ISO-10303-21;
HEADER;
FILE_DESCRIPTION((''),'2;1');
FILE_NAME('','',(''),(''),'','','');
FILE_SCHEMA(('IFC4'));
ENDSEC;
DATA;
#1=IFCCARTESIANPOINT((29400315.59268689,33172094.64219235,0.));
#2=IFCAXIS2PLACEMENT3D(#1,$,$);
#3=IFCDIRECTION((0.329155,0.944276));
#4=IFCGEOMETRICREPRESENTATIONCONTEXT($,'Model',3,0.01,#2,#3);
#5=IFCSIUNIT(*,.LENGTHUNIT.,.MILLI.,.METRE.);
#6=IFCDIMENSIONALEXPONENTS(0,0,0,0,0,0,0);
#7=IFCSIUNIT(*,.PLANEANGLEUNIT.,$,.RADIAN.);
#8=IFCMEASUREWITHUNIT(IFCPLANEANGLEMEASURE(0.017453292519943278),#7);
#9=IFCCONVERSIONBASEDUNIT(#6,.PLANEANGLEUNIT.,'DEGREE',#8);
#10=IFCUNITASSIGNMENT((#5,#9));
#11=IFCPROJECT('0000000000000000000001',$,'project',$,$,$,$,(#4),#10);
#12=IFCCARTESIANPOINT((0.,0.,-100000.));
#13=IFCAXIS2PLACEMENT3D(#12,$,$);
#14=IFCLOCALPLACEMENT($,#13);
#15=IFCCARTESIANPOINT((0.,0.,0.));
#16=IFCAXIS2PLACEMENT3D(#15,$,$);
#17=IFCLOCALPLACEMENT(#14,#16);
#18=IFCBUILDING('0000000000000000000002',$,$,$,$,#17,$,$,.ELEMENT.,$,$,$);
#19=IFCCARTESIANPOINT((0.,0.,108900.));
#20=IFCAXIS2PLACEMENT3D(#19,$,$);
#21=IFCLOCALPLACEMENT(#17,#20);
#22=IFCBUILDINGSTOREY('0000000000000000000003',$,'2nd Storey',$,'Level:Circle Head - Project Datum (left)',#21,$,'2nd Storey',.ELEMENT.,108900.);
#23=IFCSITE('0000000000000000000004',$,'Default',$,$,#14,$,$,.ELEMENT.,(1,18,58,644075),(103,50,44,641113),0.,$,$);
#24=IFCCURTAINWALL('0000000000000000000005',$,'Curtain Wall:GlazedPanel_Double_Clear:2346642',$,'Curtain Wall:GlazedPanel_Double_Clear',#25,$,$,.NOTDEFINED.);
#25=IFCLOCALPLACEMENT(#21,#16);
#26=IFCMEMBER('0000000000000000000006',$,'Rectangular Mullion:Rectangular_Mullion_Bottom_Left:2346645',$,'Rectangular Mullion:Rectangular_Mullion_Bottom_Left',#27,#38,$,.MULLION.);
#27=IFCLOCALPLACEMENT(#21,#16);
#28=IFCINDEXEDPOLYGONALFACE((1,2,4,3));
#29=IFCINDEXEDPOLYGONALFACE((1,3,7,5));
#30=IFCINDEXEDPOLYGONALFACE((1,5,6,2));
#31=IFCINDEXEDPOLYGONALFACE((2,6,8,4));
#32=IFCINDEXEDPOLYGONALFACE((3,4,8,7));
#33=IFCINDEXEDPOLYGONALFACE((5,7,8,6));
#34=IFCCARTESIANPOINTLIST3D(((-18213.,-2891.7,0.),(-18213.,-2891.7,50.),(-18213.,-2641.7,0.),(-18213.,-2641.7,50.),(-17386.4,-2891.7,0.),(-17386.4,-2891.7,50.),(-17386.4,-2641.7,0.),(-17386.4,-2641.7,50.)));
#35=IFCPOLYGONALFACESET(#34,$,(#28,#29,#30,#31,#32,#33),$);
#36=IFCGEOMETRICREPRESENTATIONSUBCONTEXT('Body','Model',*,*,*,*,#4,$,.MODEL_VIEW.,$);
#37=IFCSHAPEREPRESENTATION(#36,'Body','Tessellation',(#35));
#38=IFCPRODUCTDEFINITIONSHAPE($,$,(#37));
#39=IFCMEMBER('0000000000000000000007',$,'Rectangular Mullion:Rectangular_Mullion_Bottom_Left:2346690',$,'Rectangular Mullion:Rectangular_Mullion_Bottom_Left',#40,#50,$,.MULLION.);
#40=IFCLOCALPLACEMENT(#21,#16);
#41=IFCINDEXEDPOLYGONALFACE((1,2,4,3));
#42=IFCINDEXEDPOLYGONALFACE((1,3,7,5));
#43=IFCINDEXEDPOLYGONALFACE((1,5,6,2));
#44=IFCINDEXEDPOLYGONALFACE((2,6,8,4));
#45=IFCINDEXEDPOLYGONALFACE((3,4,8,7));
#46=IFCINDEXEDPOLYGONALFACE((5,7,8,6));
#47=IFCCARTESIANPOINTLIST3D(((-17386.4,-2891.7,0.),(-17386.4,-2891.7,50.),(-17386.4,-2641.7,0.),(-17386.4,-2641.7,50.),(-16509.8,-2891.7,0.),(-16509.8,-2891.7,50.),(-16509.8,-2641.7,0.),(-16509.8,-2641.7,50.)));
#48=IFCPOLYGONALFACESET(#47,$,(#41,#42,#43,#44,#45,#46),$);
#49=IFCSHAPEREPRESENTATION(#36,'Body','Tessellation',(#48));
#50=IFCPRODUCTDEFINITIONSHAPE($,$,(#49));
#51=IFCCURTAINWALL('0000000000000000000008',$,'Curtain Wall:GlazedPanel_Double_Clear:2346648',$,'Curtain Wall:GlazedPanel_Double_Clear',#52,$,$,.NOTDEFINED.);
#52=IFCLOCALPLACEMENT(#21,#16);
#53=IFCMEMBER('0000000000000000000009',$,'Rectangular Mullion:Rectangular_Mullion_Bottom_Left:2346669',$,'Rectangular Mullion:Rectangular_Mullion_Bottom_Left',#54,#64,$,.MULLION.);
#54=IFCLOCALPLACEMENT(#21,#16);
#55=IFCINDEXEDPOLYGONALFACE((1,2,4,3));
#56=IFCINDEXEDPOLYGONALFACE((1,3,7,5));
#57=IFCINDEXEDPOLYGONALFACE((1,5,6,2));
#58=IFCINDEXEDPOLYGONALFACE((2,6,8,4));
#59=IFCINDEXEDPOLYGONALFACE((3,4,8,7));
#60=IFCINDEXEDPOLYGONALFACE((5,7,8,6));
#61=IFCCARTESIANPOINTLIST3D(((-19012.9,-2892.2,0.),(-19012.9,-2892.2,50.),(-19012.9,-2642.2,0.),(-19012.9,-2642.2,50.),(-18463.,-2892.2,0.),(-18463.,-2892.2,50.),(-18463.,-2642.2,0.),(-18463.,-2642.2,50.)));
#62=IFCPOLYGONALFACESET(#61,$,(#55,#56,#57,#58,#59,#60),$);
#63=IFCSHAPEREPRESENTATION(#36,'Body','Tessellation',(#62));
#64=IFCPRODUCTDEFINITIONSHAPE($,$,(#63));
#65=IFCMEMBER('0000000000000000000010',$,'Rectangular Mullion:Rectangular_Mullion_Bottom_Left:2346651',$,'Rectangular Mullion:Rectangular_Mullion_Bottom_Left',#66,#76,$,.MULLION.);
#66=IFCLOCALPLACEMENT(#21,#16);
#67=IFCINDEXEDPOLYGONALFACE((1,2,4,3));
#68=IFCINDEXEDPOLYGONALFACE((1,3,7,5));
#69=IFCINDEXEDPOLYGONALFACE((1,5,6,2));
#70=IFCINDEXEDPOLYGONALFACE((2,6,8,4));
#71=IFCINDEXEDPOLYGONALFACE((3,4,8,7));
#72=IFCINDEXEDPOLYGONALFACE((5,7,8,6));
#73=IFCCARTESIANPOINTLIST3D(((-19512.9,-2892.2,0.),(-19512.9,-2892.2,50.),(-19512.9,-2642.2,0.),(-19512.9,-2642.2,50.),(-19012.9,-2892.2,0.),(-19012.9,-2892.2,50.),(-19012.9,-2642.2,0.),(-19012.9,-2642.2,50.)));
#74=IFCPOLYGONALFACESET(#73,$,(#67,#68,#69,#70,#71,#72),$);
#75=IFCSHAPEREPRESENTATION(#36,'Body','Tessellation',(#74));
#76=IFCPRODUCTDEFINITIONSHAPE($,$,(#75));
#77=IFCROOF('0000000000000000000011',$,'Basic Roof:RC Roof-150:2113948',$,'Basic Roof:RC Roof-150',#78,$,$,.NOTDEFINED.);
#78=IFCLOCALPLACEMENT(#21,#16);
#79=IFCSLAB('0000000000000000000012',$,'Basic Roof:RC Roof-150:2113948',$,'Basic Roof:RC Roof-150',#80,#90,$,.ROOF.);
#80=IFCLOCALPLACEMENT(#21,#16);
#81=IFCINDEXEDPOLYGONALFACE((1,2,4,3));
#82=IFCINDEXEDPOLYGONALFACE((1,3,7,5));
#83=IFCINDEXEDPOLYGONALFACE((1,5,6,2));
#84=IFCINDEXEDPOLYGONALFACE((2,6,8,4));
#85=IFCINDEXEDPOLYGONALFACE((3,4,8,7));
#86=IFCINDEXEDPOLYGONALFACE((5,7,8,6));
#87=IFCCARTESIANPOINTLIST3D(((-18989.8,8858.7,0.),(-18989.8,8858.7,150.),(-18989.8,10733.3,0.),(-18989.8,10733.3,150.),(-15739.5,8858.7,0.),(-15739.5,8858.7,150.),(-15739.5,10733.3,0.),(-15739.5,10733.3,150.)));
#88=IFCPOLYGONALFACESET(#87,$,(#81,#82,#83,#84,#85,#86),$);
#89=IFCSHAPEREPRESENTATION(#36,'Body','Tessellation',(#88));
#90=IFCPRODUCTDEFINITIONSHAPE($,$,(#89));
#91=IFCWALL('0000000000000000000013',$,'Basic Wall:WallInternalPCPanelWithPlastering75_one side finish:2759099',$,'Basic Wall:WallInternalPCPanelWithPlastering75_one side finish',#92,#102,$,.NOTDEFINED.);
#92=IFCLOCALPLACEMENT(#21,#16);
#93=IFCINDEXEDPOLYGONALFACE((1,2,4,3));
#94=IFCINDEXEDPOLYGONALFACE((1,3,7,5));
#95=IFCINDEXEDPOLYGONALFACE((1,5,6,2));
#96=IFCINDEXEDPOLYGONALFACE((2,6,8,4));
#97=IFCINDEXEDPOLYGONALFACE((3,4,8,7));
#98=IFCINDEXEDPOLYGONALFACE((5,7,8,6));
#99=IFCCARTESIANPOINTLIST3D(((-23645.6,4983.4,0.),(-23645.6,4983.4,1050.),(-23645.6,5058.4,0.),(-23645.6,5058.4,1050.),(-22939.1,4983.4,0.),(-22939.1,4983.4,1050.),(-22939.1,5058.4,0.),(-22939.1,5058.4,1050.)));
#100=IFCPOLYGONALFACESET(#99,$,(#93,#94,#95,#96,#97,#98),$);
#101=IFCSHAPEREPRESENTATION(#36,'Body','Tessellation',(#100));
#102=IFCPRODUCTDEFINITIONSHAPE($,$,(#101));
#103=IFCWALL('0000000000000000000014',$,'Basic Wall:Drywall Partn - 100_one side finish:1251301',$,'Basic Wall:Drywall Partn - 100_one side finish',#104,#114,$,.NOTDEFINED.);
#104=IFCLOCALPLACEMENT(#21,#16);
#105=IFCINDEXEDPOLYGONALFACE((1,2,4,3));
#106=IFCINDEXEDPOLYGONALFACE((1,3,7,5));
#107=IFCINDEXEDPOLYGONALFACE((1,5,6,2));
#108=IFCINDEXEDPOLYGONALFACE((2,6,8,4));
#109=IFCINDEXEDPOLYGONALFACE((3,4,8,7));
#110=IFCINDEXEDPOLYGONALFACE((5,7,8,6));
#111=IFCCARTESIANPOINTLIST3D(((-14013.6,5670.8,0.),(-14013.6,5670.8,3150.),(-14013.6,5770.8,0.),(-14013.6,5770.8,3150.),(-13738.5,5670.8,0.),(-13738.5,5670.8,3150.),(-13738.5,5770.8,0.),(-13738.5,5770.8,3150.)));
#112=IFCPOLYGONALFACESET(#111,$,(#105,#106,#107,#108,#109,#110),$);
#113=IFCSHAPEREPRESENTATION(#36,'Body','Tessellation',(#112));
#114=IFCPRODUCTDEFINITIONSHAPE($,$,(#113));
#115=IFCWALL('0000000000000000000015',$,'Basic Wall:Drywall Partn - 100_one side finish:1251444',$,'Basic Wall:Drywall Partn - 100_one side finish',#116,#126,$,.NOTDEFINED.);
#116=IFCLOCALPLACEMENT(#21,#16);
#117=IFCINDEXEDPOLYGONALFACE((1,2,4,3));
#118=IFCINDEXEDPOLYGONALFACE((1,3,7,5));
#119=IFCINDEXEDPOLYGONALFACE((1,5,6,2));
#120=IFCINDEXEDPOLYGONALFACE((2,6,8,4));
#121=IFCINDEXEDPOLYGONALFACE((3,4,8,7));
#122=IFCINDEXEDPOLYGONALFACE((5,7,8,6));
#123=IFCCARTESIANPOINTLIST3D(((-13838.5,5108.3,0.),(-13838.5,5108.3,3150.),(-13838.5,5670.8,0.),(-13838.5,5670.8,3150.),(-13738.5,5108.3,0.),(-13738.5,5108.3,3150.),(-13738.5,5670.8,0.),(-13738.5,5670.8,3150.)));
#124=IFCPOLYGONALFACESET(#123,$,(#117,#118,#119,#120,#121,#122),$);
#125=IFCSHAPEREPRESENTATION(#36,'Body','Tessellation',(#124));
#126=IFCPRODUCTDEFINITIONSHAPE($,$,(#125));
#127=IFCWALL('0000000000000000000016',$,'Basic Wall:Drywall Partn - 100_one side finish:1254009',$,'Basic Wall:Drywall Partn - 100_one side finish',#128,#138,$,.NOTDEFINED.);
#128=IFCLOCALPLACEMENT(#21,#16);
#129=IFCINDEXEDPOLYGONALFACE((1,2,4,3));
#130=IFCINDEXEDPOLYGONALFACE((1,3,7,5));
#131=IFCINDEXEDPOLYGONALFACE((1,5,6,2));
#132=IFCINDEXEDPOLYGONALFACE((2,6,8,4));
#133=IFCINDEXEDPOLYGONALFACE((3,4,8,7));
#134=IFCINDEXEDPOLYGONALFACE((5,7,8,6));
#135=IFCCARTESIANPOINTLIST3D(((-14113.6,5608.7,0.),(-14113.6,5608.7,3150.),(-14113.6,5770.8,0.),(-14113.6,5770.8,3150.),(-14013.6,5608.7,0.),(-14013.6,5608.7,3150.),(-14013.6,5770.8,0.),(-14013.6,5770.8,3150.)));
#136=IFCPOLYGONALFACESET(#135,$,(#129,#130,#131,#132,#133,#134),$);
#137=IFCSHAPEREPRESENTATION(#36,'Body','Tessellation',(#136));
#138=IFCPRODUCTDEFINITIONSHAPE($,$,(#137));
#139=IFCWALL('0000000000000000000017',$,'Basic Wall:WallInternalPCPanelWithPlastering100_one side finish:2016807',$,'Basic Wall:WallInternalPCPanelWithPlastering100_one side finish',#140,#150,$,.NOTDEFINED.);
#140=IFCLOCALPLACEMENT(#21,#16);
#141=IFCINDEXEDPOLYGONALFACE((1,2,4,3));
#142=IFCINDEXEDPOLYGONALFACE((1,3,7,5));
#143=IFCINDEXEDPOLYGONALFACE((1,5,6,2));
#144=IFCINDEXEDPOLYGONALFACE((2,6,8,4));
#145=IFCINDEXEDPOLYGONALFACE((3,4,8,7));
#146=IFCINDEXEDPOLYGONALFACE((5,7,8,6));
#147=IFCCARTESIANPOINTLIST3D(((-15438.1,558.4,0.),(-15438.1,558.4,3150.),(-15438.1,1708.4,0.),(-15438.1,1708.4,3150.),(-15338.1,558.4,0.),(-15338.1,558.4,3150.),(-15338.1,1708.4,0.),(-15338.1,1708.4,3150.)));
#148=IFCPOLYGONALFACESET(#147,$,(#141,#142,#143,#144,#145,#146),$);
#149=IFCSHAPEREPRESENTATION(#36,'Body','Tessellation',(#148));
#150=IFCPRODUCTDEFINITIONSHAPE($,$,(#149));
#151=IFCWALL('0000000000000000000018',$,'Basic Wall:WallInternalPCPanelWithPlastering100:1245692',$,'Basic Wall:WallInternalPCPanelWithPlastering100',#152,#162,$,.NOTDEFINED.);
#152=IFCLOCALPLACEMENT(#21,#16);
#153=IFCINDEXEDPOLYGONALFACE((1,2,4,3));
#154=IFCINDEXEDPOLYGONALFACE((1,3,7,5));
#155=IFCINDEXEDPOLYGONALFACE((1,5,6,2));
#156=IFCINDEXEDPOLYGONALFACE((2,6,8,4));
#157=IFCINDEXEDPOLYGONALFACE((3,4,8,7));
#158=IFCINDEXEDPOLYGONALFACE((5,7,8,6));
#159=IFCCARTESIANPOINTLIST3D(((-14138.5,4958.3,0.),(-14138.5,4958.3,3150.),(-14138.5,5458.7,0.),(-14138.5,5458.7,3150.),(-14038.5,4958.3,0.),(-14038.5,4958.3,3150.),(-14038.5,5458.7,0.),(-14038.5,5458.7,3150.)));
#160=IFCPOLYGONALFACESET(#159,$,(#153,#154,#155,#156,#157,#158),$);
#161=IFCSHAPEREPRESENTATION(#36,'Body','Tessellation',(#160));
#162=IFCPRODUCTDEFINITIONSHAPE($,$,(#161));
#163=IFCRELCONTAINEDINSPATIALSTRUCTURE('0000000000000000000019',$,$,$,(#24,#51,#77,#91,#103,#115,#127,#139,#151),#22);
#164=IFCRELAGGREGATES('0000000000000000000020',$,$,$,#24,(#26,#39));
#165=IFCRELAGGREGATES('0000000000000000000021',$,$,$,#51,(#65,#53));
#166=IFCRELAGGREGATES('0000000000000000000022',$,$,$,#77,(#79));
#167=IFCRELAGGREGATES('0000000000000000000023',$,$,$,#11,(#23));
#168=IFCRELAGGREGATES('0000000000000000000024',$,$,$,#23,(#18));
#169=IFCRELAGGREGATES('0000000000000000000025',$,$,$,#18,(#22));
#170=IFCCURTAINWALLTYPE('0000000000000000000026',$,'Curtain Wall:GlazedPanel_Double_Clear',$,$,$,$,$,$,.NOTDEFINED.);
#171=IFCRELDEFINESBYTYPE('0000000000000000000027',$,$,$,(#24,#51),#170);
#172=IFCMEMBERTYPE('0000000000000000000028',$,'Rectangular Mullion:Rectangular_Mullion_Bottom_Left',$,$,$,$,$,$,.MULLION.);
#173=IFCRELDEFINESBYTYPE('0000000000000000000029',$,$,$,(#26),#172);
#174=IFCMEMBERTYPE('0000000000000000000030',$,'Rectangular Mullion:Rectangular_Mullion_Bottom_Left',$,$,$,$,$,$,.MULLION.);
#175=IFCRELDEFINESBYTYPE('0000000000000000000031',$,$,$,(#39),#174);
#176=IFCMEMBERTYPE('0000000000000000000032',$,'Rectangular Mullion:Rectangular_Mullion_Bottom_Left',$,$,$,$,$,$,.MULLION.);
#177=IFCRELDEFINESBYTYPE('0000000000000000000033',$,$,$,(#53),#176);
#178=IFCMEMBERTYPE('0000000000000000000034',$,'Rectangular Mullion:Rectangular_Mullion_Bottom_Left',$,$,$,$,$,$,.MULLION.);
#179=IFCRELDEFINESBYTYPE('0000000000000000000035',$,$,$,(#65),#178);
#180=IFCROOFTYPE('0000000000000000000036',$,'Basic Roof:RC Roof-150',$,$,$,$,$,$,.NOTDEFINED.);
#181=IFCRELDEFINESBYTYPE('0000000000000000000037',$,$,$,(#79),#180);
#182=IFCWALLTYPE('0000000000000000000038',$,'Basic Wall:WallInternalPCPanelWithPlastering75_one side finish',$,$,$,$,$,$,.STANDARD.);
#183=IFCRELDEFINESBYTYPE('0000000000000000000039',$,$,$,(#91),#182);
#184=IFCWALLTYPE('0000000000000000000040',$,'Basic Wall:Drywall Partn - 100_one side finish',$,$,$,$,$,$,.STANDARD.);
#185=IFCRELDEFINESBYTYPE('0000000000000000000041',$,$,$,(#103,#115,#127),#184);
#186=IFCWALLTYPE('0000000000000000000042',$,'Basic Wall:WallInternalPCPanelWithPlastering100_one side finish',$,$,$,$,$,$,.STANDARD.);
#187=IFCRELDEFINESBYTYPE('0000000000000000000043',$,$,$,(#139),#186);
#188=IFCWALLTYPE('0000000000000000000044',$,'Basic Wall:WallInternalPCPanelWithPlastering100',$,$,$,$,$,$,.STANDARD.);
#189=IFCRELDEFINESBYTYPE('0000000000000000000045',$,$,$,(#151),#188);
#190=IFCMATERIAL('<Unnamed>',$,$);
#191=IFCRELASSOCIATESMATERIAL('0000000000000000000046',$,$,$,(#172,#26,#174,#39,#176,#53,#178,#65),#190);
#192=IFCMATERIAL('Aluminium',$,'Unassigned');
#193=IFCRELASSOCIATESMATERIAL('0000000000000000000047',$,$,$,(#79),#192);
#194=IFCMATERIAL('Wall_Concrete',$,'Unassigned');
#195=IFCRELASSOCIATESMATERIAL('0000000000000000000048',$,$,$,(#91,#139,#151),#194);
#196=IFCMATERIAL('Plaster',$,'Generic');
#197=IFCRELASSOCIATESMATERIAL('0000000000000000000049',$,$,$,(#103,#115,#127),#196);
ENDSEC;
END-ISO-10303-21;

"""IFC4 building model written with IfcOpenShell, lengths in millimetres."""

from ifc_helpers import new_model, entity, si_unit, converted_unit, direction, frame, origin, place, context, subcontext, project, spatial, indexed_curve, outline, extrude, source, transform, mapped, material, type_object, type_shapes, element, aggregate, save


model = new_model("IFC4")

# Units and contexts
model_context = context("Model", 3, precision=0.01, world=frame((29400315.59268689, 33172094.64219235, 0.0)), true_north=direction((0.329155, 0.944276)))
body_context = subcontext(model_context, "Body", "Model", "MODEL_VIEW")
ifc_project = project(units=[si_unit("LENGTHUNIT", "METRE", prefix="MILLI"), converted_unit("PLANEANGLEUNIT", "DEGREE", entity("IfcPlaneAngleMeasure", 0.017453292519943278), si_unit("PLANEANGLEUNIT", "RADIAN"), dimensions=[0, 0, 0, 0, 0, 0, 0])], contexts=[model_context])

# Site, building, storey
site_placement = place(None, frame((0.0, 0.0, -100000.0)))
site = spatial("IfcSite", under=ifc_project, at=site_placement, Name="Default", CompositionType="ELEMENT", RefLatitude=(1, 18, 58, 644075), RefLongitude=(103, 50, 44, 641113), RefElevation=0.0)
building_placement = place(site_placement, origin())
building = spatial("IfcBuilding", under=site, at=building_placement, CompositionType="ELEMENT")
storey_placement = place(building_placement, frame((0.0, 0.0, 108900.0)))
storey = spatial("IfcBuildingStorey", under=building, at=storey_placement, Name="2nd Storey", ObjectType="Level:Circle Head - Project Datum (left)", LongName="2nd Storey", CompositionType="ELEMENT", Elevation=108900.0)

# Curtain walls, members
curtain_wall_type = type_object("IfcCurtainWallType", Name="Curtain Wall:GlazedPanel_Double_Clear", PredefinedType="NOTDEFINED")
curtain_wall_1_placement = place(storey_placement, frame((0.0, 0.0, -108900.0)))
curtain_wall_1 = element("IfcCurtainWall", 1, at=curtain_wall_1_placement, inside=storey, type_object=curtain_wall_type, Name="Curtain Wall:GlazedPanel_Double_Clear:2346642", ObjectType="Curtain Wall:GlazedPanel_Double_Clear", PredefinedType="NOTDEFINED")
ifc_material_1 = material(Name="<Unnamed>")
member_type_1 = type_object("IfcMemberType", Name="Rectangular Mullion:Rectangular_Mullion_Bottom_Left", PredefinedType="MULLION", material=ifc_material_1)
shared_shape_1 = source(origin(), body_context, "Body", "SweptSolid", [
    extrude(outline(indexed_curve([(-25.0, -125.0), (25.0, -125.0), (25.0, 125.0), (-25.0, 125.0), (-25.0, -125.0)], self_intersect=False)), frame((-25.0, 0.0, -826.6), z_axis=(0.0, 0.0, 1.0), x_axis=(-1.0, 0.0, 0.0)), (0.0, 0.0, 1.0), 826.6),
])
type_shapes(member_type_1, [shared_shape_1])
member_1_placement = place(curtain_wall_1_placement, frame((-18213.0, -2766.7, 108900.0), z_axis=(-1.0, 0.0, 0.0), x_axis=(0.0, 0.0, -1.0)))
member_1 = element("IfcMember", 2, at=member_1_placement, type_object=member_type_1, material=ifc_material_1, Name="Rectangular Mullion:Rectangular_Mullion_Bottom_Left:2346645", ObjectType="Rectangular Mullion:Rectangular_Mullion_Bottom_Left", PredefinedType="MULLION", context=body_context, shape_type="MappedRepresentation", body=[
    mapped(shared_shape_1, transform((0.0, 0.0, 0.0), scale=1.0)),
])
member_type_2 = type_object("IfcMemberType", Name="Rectangular Mullion:Rectangular_Mullion_Bottom_Left", PredefinedType="MULLION", material=ifc_material_1)
shared_shape_2 = source(origin(), body_context, "Body", "SweptSolid", [
    extrude(outline(indexed_curve([(-25.0, -125.0), (25.0, -125.0), (25.0, 125.0), (-25.0, 125.0), (-25.0, -125.0)], self_intersect=False)), frame((-25.0, 0.0, -876.6), z_axis=(0.0, 0.0, 1.0), x_axis=(-1.0, 0.0, 0.0)), (0.0, 0.0, 1.0), 876.6),
])
type_shapes(member_type_2, [shared_shape_2])
member_2_placement = place(curtain_wall_1_placement, frame((-17386.4, -2766.7, 108900.0), z_axis=(-1.0, 0.0, 0.0), x_axis=(0.0, 0.0, -1.0)))
member_2 = element("IfcMember", 3, at=member_2_placement, type_object=member_type_2, material=ifc_material_1, Name="Rectangular Mullion:Rectangular_Mullion_Bottom_Left:2346690", ObjectType="Rectangular Mullion:Rectangular_Mullion_Bottom_Left", PredefinedType="MULLION", context=body_context, shape_type="MappedRepresentation", body=[
    mapped(shared_shape_2, transform((0.0, 0.0, 0.0), scale=1.0)),
])
aggregate(curtain_wall_1, [member_1, member_2])
curtain_wall_2_placement = place(storey_placement, frame((0.0, 0.0, -108900.0)))
curtain_wall_2 = element("IfcCurtainWall", 4, at=curtain_wall_2_placement, inside=storey, type_object=curtain_wall_type, Name="Curtain Wall:GlazedPanel_Double_Clear:2346648", ObjectType="Curtain Wall:GlazedPanel_Double_Clear", PredefinedType="NOTDEFINED")
member_type_3 = type_object("IfcMemberType", Name="Rectangular Mullion:Rectangular_Mullion_Bottom_Left", PredefinedType="MULLION", material=ifc_material_1)
shared_shape_3 = source(origin(), body_context, "Body", "SweptSolid", [
    extrude(outline(indexed_curve([(-25.0, -125.0), (25.0, -125.0), (25.0, 125.0), (-25.0, 125.0), (-25.0, -125.0)], self_intersect=False)), frame((-25.0, 0.0, -549.9), z_axis=(0.0, 0.0, 1.0), x_axis=(-1.0, 0.0, 0.0)), (0.0, 0.0, 1.0), 549.9),
])
type_shapes(member_type_3, [shared_shape_3])
member_3_placement = place(curtain_wall_2_placement, frame((-19012.9, -2767.2, 108900.0), z_axis=(-1.0, 0.0, 0.0), x_axis=(0.0, 0.0, -1.0)))
member_3 = element("IfcMember", 5, at=member_3_placement, type_object=member_type_3, material=ifc_material_1, Name="Rectangular Mullion:Rectangular_Mullion_Bottom_Left:2346669", ObjectType="Rectangular Mullion:Rectangular_Mullion_Bottom_Left", PredefinedType="MULLION", context=body_context, shape_type="MappedRepresentation", body=[
    mapped(shared_shape_3, transform((0.0, 0.0, 0.0), scale=1.0)),
])
member_type_4 = type_object("IfcMemberType", Name="Rectangular Mullion:Rectangular_Mullion_Bottom_Left", PredefinedType="MULLION", material=ifc_material_1)
shared_shape_4 = source(origin(), body_context, "Body", "SweptSolid", [
    extrude(outline(indexed_curve([(-25.0, -125.0), (25.0, -125.0), (25.0, 125.0), (-25.0, 125.0), (-25.0, -125.0)], self_intersect=False)), frame((-25.0, 0.0, -499.9), z_axis=(0.0, 0.0, 1.0), x_axis=(-1.0, 0.0, 0.0)), (0.0, 0.0, 1.0), 499.9),
])
type_shapes(member_type_4, [shared_shape_4])
member_4_placement = place(curtain_wall_2_placement, frame((-19512.9, -2767.2, 108900.0), z_axis=(-1.0, 0.0, 0.0), x_axis=(0.0, 0.0, -1.0)))
member_4 = element("IfcMember", 6, at=member_4_placement, type_object=member_type_4, material=ifc_material_1, Name="Rectangular Mullion:Rectangular_Mullion_Bottom_Left:2346651", ObjectType="Rectangular Mullion:Rectangular_Mullion_Bottom_Left", PredefinedType="MULLION", context=body_context, shape_type="MappedRepresentation", body=[
    mapped(shared_shape_4, transform((0.0, 0.0, 0.0), scale=1.0)),
])
aggregate(curtain_wall_2, [member_4, member_3])

# Roof, slab
roof_placement = place(storey_placement, frame((-18989.8, 8858.7, 0.0)))
roof = element("IfcRoof", 7, at=roof_placement, inside=storey, Name="Basic Roof:RC Roof-150:2113948", ObjectType="Basic Roof:RC Roof-150", PredefinedType="NOTDEFINED")
ifc_material_2 = material(Name="Aluminium", Category="Unassigned")
roof_type = type_object("IfcRoofType", Name="Basic Roof:RC Roof-150", PredefinedType="NOTDEFINED")
slab_placement = place(roof_placement, origin())
slab = element("IfcSlab", 8, at=slab_placement, type_object=roof_type, material=ifc_material_2, Name="Basic Roof:RC Roof-150:2113948", ObjectType="Basic Roof:RC Roof-150", PredefinedType="ROOF", context=body_context, shape_type="SweptSolid", body=[
    extrude(outline(indexed_curve([(-1625.1, 937.3), (-1625.1, -937.3), (1625.1, -937.3), (1625.1, 937.3), (-1625.1, 937.3)], self_intersect=False)), frame((1625.1, 937.3, 0.0)), (0.0, 0.0, 1.0), 150.0),
])
aggregate(roof, [slab])

# Walls
ifc_material_3 = material(Name="Wall_Concrete", Category="Unassigned")
wall_type_1 = type_object("IfcWallType", Name="Basic Wall:WallInternalPCPanelWithPlastering75_one side finish", PredefinedType="STANDARD")
wall_1_placement = place(storey_placement, frame((-22939.1, 5020.9, 0.0), z_axis=(0.0, 0.0, 1.0), x_axis=(-1.0, 0.0, 0.0)))
element("IfcWall", 9, at=wall_1_placement, inside=storey, type_object=wall_type_1, material=ifc_material_3, Name="Basic Wall:WallInternalPCPanelWithPlastering75_one side finish:2759099", ObjectType="Basic Wall:WallInternalPCPanelWithPlastering75_one side finish", PredefinedType="NOTDEFINED", context=body_context, shape_type="SweptSolid", body=[
    extrude(outline(indexed_curve([(706.5, 37.5), (0.0, 37.5), (0.0, -37.5), (706.5, -37.5), (706.5, 37.5)], self_intersect=False)), origin(), (0.0, 0.0, 1.0), 1050.0),
])
ifc_material_4 = material(Name="Plaster", Category="Generic")
wall_type_2 = type_object("IfcWallType", Name="Basic Wall:Drywall Partn - 100_one side finish", PredefinedType="STANDARD")
wall_2_placement = place(storey_placement, frame((-14013.6, 5720.8, 0.0)))
element("IfcWall", 10, at=wall_2_placement, inside=storey, type_object=wall_type_2, material=ifc_material_4, Name="Basic Wall:Drywall Partn - 100_one side finish:1251301", ObjectType="Basic Wall:Drywall Partn - 100_one side finish", PredefinedType="NOTDEFINED", context=body_context, shape_type="SweptSolid", body=[
    extrude(outline(indexed_curve([(275.1, 50.0), (0.0, 50.0), (0.0, -50.0), (275.1, -50.0), (275.1, 50.0)], self_intersect=False)), origin(), (0.0, 0.0, 1.0), 3150.0),
])
wall_3_placement = place(storey_placement, frame((-13788.5, 5670.8, 0.0), z_axis=(0.0, 0.0, 1.0), x_axis=(0.0, -1.0, 0.0)))
element("IfcWall", 11, at=wall_3_placement, inside=storey, type_object=wall_type_2, material=ifc_material_4, Name="Basic Wall:Drywall Partn - 100_one side finish:1251444", ObjectType="Basic Wall:Drywall Partn - 100_one side finish", PredefinedType="NOTDEFINED", context=body_context, shape_type="SweptSolid", body=[
    extrude(outline(indexed_curve([(562.5, 50.0), (0.0, 50.0), (0.0, -50.0), (562.5, -50.0), (562.5, 50.0)], self_intersect=False)), origin(), (0.0, 0.0, 1.0), 3150.0),
])
wall_4_placement = place(storey_placement, frame((-14063.6, 5608.7, 0.0), z_axis=(0.0, 0.0, 1.0), x_axis=(0.0, 1.0, 0.0)))
element("IfcWall", 12, at=wall_4_placement, inside=storey, type_object=wall_type_2, material=ifc_material_4, Name="Basic Wall:Drywall Partn - 100_one side finish:1254009", ObjectType="Basic Wall:Drywall Partn - 100_one side finish", PredefinedType="NOTDEFINED", context=body_context, shape_type="SweptSolid", body=[
    extrude(outline(indexed_curve([(162.1, 50.0), (0.0, 50.0), (0.0, -50.0), (162.1, -50.0), (162.1, 50.0)], self_intersect=False)), origin(), (0.0, 0.0, 1.0), 3150.0),
])
wall_type_3 = type_object("IfcWallType", Name="Basic Wall:WallInternalPCPanelWithPlastering100_one side finish", PredefinedType="STANDARD")
wall_5_placement = place(storey_placement, frame((-15388.1, 558.4, 0.0), z_axis=(0.0, 0.0, 1.0), x_axis=(0.0, 1.0, 0.0)))
element("IfcWall", 13, at=wall_5_placement, inside=storey, type_object=wall_type_3, material=ifc_material_3, Name="Basic Wall:WallInternalPCPanelWithPlastering100_one side finish:2016807", ObjectType="Basic Wall:WallInternalPCPanelWithPlastering100_one side finish", PredefinedType="NOTDEFINED", context=body_context, shape_type="SweptSolid", body=[
    extrude(outline(indexed_curve([(1150.0, 50.0), (0.0, 50.0), (0.0, -50.0), (1150.0, -50.0), (1150.0, 50.0)], self_intersect=False)), origin(), (0.0, 0.0, 1.0), 3150.0),
])
wall_type_4 = type_object("IfcWallType", Name="Basic Wall:WallInternalPCPanelWithPlastering100", PredefinedType="STANDARD")
wall_6_placement = place(storey_placement, frame((-14088.5, 5458.7, 0.0), z_axis=(0.0, 0.0, 1.0), x_axis=(0.0, -1.0, 0.0)))
element("IfcWall", 14, at=wall_6_placement, inside=storey, type_object=wall_type_4, material=ifc_material_3, Name="Basic Wall:WallInternalPCPanelWithPlastering100:1245692", ObjectType="Basic Wall:WallInternalPCPanelWithPlastering100", PredefinedType="NOTDEFINED", context=body_context, shape_type="SweptSolid", body=[
    extrude(outline(indexed_curve([(500.4, 50.0), (0.0, 50.0), (0.0, -50.0), (500.4, -50.0), (500.4, 50.0)], self_intersect=False)), origin(), (0.0, 0.0, 1.0), 3150.0),
])

save(model, "model.ifc")
